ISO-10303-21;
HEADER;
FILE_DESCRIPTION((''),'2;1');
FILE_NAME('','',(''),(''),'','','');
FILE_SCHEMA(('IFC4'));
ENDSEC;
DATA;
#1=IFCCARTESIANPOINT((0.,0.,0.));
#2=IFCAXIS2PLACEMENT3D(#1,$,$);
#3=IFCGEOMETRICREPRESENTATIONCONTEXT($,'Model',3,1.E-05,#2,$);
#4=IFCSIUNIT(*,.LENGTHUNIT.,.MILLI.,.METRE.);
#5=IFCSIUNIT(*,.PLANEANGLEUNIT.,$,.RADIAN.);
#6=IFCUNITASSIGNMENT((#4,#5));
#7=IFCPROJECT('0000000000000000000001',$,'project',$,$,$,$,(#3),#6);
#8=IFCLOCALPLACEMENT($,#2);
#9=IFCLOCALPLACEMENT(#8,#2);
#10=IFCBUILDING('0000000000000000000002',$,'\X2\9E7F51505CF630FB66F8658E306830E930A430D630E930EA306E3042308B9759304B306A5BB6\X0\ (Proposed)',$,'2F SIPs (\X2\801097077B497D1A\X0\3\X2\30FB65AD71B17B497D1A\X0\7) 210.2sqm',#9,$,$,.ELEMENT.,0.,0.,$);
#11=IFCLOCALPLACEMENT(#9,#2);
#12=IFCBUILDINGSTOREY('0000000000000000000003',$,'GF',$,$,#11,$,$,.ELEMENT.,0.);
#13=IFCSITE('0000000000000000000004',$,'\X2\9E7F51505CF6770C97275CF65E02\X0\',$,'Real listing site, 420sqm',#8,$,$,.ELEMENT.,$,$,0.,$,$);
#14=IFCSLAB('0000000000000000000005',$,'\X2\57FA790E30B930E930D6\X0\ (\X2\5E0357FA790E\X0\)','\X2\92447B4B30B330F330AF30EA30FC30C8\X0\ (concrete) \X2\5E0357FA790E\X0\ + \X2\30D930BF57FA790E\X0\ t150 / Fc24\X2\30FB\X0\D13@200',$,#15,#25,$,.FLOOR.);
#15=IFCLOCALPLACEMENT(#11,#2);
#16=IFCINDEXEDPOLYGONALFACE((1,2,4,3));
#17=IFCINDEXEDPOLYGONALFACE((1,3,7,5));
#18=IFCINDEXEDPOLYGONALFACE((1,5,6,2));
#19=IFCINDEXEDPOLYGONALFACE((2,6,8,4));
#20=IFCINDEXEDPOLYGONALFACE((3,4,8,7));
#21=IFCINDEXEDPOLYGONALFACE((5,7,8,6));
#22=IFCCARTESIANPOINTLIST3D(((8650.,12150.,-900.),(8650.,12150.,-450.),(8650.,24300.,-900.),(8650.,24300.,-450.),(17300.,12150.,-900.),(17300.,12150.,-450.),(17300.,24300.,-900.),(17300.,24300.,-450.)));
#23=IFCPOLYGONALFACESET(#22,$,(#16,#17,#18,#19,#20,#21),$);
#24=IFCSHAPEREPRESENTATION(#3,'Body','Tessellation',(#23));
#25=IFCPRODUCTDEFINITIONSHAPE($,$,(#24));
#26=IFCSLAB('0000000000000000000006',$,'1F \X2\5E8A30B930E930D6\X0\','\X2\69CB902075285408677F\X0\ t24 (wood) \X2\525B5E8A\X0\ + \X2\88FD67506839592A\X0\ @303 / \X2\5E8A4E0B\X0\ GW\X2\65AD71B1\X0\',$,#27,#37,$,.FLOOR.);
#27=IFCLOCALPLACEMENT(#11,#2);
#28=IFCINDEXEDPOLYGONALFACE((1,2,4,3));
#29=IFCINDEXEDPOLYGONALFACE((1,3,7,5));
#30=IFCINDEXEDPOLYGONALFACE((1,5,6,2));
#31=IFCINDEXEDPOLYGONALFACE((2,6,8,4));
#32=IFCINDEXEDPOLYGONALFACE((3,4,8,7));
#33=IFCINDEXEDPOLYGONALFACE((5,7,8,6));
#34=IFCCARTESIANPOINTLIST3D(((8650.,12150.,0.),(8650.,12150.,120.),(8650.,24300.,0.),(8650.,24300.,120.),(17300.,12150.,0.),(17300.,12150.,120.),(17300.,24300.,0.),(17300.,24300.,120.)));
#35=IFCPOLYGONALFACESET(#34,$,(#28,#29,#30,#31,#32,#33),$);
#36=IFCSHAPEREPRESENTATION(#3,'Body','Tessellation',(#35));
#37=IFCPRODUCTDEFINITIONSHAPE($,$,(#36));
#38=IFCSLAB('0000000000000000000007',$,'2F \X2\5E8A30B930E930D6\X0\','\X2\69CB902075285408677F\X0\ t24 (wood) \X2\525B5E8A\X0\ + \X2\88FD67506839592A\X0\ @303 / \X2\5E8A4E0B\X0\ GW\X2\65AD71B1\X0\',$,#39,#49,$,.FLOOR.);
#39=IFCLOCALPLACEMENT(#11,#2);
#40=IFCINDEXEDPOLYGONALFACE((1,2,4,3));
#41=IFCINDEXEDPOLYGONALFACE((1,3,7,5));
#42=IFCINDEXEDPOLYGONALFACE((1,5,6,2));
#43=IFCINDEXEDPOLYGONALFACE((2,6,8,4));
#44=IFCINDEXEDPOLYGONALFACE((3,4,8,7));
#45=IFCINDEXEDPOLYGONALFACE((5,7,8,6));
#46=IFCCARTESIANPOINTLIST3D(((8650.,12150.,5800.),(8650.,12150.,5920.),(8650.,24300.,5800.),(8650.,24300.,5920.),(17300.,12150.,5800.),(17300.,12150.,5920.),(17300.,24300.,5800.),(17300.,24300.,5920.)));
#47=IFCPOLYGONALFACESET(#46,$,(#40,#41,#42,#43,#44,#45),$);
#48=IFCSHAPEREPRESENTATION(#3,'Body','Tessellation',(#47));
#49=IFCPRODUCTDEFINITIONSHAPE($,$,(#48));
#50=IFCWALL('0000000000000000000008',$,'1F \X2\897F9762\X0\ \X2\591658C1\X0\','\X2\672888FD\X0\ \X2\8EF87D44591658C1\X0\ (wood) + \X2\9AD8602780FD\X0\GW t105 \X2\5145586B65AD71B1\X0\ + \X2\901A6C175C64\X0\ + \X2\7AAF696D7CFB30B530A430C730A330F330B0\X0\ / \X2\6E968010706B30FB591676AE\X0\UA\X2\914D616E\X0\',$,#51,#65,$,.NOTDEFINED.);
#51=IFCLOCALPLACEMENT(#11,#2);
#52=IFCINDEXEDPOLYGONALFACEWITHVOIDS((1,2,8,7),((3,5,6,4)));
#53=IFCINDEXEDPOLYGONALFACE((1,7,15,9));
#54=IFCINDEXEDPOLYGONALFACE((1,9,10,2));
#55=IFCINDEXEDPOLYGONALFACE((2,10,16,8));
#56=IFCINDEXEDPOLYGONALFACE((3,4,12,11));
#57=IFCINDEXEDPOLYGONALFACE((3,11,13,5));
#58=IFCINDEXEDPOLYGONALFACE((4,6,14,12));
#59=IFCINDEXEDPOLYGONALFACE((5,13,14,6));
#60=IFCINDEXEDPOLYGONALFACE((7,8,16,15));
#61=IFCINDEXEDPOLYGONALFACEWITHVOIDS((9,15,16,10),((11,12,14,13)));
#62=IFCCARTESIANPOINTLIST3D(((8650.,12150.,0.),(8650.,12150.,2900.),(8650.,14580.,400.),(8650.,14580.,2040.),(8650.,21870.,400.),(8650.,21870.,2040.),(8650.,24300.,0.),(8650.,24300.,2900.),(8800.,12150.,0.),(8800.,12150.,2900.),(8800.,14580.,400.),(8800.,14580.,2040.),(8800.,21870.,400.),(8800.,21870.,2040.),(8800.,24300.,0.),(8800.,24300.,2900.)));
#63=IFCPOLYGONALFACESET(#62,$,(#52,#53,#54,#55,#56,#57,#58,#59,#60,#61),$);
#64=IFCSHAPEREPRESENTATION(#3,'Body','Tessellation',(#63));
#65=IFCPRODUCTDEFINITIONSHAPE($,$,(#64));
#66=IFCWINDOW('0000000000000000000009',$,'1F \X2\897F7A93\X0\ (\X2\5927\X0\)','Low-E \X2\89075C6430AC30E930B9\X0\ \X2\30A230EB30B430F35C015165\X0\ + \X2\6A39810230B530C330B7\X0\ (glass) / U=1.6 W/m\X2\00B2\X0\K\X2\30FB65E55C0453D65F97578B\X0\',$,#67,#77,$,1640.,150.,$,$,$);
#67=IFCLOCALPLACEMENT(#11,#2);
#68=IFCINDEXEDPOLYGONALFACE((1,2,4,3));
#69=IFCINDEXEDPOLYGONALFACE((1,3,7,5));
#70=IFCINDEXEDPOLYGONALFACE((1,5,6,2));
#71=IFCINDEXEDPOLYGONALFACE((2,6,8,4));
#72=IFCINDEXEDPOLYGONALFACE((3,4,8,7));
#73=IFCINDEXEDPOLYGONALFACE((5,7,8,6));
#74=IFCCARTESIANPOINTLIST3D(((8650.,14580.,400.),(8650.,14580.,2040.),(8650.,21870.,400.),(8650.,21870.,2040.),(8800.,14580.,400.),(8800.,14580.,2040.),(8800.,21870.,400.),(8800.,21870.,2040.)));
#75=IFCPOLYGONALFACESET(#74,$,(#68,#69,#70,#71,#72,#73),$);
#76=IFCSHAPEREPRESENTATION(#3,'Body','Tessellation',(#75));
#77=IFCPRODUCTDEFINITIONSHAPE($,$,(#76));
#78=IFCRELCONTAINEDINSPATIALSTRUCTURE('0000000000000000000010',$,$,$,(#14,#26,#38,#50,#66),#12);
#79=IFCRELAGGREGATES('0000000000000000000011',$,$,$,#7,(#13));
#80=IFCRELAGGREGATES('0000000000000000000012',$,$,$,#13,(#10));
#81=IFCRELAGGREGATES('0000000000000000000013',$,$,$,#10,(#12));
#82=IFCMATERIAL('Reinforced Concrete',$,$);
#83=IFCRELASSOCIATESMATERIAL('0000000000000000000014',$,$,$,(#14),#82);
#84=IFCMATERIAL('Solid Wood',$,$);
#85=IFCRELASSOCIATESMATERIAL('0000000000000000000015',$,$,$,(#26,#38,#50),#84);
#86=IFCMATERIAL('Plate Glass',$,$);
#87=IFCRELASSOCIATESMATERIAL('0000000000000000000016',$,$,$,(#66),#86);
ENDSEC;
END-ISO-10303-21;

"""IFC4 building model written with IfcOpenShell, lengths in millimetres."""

from ifc_helpers import new_model, si_unit, frame, frame_2d, origin, place, context, project, spatial, rectangle, extrude, material, element, fill, save


model = new_model("IFC4")

# Units and contexts
model_context = context("Model", 3, precision=1e-05, world=origin())
ifc_project = project(units=[si_unit("LENGTHUNIT", "METRE", prefix="MILLI"), si_unit("PLANEANGLEUNIT", "RADIAN")], contexts=[model_context])

# Site, building, storey
site_placement = place(None, origin())
site = spatial("IfcSite", under=ifc_project, at=site_placement, Name="鹿児島県霧島市", ObjectType="Real listing site, 420sqm", CompositionType="ELEMENT", RefElevation=0.0)
building_placement = place(site_placement, origin())
building = spatial("IfcBuilding", under=site, at=building_placement, Name="鹿児島・書斎とライブラリのある静かな家 (Proposed)", ObjectType="2F SIPs (耐震等級3・断熱等級7) 210.2sqm", CompositionType="ELEMENT", ElevationOfRefHeight=0.0, ElevationOfTerrain=0.0)
storey_placement = place(building_placement, origin())
storey = spatial("IfcBuildingStorey", under=building, at=storey_placement, Name="GF", CompositionType="ELEMENT", Elevation=0.0)

# Shared definitions
ifc_material_1 = material(Name="Solid Wood")

# Slabs
ifc_material_2 = material(Name="Reinforced Concrete")
slab_1_placement = place(storey_placement, frame((4325.0, 6075.0, -450.0)))
element("IfcSlab", 1, at=slab_1_placement, inside=storey, material=ifc_material_2, Name="基礎スラブ (布基礎)", Description="鉄筋コンクリート (concrete) 布基礎 + ベタ基礎 t150 / Fc24・D13@200", PredefinedType="FLOOR", context=model_context, shape_type="SweptSolid", body=[
    extrude(rectangle(XDim=8650.0, YDim=12150.0, at=frame_2d((4325.0, 6075.0))), frame((4325.0, 6075.0, -450.0)), (0.0, 0.0, 1.0), 450.0),
])
slab_2_placement = place(storey_placement, frame((4325.0, 6075.0, 0.0)))
element("IfcSlab", 2, at=slab_2_placement, inside=storey, material=ifc_material_1, Name="1F 床スラブ", Description="構造用合板 t24 (wood) 剛床 + 製材根太 @303 / 床下 GW断熱", PredefinedType="FLOOR", context=model_context, shape_type="SweptSolid", body=[
    extrude(rectangle(XDim=8650.0, YDim=12150.0, at=frame_2d((4325.0, 6075.0))), frame((4325.0, 6075.0, 0.0)), (0.0, 0.0, 1.0), 120.0),
])
slab_3_placement = place(storey_placement, frame((4325.0, 6075.0, 2900.0)))
element("IfcSlab", 3, at=slab_3_placement, inside=storey, material=ifc_material_1, Name="2F 床スラブ", Description="構造用合板 t24 (wood) 剛床 + 製材根太 @303 / 床下 GW断熱", PredefinedType="FLOOR", context=model_context, shape_type="SweptSolid", body=[
    extrude(rectangle(XDim=8650.0, YDim=12150.0, at=frame_2d((4325.0, 6075.0))), frame((4325.0, 6075.0, 2900.0)), (0.0, 0.0, 1.0), 120.0),
])

# Shared definitions
ifc_material_3 = material(Name="Plate Glass")

# Wall, opening, window
wall_1_placement = place(storey_placement, frame((4325.0, 6075.0, 0.0)))
wall_1 = element("IfcWall", 4, at=wall_1_placement, inside=storey, material=ifc_material_1, Name="1F 西面 外壁", Description="木製 軸組外壁 (wood) + 高性能GW t105 充填断熱 + 通気層 + 窯業系サイディング / 準耐火・外皮UA配慮", PredefinedType="NOTDEFINED", context=model_context, shape_type="SweptSolid", body=[
    extrude(rectangle(XDim=150.0, YDim=12150.0, at=frame_2d((75.0, 6075.0))), frame((4325.0, 6075.0, 0.0)), (0.0, 0.0, 1.0), 2900.0),
])
opening_1_placement = place(storey_placement, frame((4325.0, 7290.0, 200.0)))
opening_1 = element("IfcOpeningElement", 5, at=opening_1_placement, cuts=wall_1, PredefinedType="NOTDEFINED", context=model_context, shape_type="SweptSolid", body=[
    extrude(rectangle(XDim=150.0, YDim=7290.0, at=frame_2d((75.0, 3645.0))), frame((4325.0, 7290.0, 200.0)), (0.0, 0.0, 1.0), 1640.0),
])
window_1_placement = place(storey_placement, frame((4325.0, 7290.0, 200.0)))
window_1 = element("IfcWindow", 6, at=window_1_placement, inside=storey, material=ifc_material_3, Name="1F 西窓 (大)", Description="Low-E 複層ガラス アルゴン封入 + 樹脂サッシ (glass) / U=1.6 W/m²K・日射取得型", OverallHeight=1640.0, OverallWidth=150.0, context=model_context, shape_type="SweptSolid", body=[
    extrude(rectangle(XDim=150.0, YDim=7290.0, at=frame_2d((75.0, 3645.0))), frame((4325.0, 7290.0, 200.0)), (0.0, 0.0, 1.0), 1640.0),
])
fill(opening_1, window_1)

save(model, "model.ifc")
